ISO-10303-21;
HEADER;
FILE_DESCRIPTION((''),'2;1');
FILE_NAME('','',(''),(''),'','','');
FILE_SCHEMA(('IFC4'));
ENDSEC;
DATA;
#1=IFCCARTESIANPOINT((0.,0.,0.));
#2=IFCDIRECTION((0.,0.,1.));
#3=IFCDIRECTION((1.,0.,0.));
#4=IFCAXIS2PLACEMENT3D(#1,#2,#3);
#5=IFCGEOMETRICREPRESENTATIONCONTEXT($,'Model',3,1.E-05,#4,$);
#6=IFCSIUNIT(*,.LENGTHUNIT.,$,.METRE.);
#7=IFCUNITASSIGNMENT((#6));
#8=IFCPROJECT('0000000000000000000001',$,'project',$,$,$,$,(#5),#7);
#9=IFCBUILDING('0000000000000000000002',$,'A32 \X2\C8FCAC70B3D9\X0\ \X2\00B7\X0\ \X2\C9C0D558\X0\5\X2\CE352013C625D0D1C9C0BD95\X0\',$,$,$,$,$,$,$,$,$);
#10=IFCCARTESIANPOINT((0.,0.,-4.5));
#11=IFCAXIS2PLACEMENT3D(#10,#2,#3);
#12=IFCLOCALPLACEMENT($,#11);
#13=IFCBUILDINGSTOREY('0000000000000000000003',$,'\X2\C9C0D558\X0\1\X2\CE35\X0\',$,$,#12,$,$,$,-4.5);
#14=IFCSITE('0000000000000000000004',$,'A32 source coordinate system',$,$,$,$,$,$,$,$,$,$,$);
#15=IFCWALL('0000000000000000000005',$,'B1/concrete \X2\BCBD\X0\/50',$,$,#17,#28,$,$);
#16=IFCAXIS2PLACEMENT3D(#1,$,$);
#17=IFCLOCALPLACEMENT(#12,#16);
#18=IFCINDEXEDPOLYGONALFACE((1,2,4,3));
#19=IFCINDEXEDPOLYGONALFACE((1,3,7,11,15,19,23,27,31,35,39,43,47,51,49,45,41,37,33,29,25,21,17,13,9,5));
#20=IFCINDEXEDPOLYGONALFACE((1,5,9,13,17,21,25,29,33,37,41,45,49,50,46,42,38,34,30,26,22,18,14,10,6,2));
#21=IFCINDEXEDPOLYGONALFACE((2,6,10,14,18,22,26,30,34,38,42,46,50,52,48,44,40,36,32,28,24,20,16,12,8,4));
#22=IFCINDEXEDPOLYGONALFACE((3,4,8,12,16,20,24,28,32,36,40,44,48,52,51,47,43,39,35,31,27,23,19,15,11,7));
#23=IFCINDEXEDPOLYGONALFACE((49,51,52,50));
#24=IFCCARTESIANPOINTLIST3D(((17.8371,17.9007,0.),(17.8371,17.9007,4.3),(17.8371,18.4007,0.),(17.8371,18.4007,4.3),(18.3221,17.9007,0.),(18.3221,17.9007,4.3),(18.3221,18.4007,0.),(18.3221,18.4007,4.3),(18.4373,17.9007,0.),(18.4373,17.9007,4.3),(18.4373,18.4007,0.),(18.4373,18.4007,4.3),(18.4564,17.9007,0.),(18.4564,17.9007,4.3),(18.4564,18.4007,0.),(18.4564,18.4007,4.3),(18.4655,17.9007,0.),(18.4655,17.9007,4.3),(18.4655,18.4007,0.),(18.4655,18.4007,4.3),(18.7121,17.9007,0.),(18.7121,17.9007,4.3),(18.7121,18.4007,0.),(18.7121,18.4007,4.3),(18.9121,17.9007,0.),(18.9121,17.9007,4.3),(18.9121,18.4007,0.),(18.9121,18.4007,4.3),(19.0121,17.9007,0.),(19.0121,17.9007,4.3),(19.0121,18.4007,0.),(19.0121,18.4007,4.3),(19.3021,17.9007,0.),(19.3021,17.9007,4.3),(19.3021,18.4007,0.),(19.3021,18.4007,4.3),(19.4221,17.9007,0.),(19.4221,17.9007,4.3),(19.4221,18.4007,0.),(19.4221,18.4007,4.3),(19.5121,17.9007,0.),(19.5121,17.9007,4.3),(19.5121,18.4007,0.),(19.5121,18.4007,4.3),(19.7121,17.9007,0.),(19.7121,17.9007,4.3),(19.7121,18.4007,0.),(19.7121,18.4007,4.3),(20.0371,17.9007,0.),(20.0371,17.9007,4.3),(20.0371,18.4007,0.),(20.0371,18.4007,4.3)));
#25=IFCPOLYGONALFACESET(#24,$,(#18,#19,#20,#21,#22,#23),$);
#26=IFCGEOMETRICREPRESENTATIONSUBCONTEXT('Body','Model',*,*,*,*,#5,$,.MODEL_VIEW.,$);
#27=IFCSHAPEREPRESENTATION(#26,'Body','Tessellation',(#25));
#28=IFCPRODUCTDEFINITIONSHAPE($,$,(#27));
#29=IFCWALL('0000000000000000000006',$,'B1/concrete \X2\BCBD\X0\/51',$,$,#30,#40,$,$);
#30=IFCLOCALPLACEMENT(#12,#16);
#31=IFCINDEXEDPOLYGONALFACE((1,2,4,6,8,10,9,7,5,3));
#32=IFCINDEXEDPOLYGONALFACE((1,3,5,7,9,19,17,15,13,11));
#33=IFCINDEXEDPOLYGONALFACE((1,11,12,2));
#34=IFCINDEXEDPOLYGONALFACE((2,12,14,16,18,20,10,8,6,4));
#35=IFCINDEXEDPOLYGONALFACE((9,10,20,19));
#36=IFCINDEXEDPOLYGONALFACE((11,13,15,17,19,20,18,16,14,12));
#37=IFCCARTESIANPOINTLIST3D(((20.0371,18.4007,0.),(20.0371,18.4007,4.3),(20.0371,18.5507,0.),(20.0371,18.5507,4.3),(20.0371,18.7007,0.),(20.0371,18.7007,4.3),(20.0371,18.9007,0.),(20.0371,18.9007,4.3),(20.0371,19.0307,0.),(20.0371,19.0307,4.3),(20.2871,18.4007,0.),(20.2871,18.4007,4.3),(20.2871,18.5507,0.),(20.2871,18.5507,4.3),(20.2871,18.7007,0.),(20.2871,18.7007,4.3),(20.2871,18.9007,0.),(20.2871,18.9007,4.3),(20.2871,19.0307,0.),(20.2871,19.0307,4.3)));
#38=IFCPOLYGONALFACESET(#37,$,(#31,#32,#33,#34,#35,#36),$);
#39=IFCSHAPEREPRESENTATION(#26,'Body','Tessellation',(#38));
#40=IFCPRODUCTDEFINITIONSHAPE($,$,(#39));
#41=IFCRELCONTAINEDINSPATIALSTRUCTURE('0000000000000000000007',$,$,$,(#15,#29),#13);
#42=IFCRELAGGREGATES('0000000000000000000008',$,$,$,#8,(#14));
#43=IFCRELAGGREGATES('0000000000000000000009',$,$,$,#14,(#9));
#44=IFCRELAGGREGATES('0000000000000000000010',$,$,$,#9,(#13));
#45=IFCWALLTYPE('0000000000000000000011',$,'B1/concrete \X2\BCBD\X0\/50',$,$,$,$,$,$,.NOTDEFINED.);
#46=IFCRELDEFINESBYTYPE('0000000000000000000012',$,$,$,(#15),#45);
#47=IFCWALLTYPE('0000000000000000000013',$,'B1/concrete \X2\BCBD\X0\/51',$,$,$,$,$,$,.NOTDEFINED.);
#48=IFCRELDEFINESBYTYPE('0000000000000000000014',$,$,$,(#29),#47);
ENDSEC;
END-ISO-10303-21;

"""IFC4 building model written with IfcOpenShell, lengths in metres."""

from ifc_helpers import new_model, si_unit, frame, origin, origin_with_axes, place, context, subcontext, project, spatial, polyline, outline, extrude, source, transform, mapped, type_object, type_shapes, element, save


model = new_model("IFC4")

# Units and contexts
model_context = context("Model", 3, precision=1e-05, world=origin_with_axes())
body_context = subcontext(model_context, "Body", "Model", "MODEL_VIEW")
ifc_project = project(units=[si_unit("LENGTHUNIT", "METRE")], contexts=[model_context])

# Site, building, storey
site = spatial("IfcSite", under=ifc_project, Name="A32 source coordinate system")
building = spatial("IfcBuilding", under=site, Name="A32 주거동 · 지하5층–옥탑지붕")
storey_placement = place(None, frame((0.0, 0.0, -4.5), z_axis=(0.0, 0.0, 1.0), x_axis=(1.0, 0.0, 0.0)))
storey = spatial("IfcBuildingStorey", under=building, at=storey_placement, Name="지하1층", Elevation=-4.5)

# Walls
wall_type_1 = type_object("IfcWallType", Name="B1/concrete 벽/50", PredefinedType="NOTDEFINED")
shared_shape_1 = source(origin(), body_context, "Body", "SweptSolid", [
    extrude(outline(polyline([(18.4373, 18.4007), (18.4564, 18.4007), (18.4655, 18.4007), (18.7121, 18.4007), (18.9121, 18.4007), (19.0121, 18.4007), (19.3021, 18.4007), (19.4221, 18.4007), (19.5121, 18.4007), (19.7121, 18.4007), (20.0371, 18.4007), (20.0371, 17.9007), (19.7121, 17.9007), (19.5121, 17.9007), (19.4221, 17.9007), (19.3021, 17.9007), (19.0121, 17.9007), (18.9121, 17.9007), (18.7121, 17.9007), (18.4655, 17.9007), (18.4564, 17.9007), (18.4373, 17.9007), (18.3221, 17.9007), (17.8371, 17.9007), (17.8371, 18.4007), (18.3221, 18.4007), (18.4373, 18.4007)])), origin(), (0.0, 0.0, 1.0), 4.3),
])
type_shapes(wall_type_1, [shared_shape_1])
wall_1_placement = place(storey_placement, origin_with_axes())
element("IfcWall", 1, at=wall_1_placement, inside=storey, type_object=wall_type_1, Name="B1/concrete 벽/50", context=body_context, shape_type="MappedRepresentation", body=[
    mapped(shared_shape_1, transform((0.0, 0.0, 0.0), scale=1.0)),
])
wall_type_2 = type_object("IfcWallType", Name="B1/concrete 벽/51", PredefinedType="NOTDEFINED")
shared_shape_2 = source(origin(), body_context, "Body", "SweptSolid", [
    extrude(outline(polyline([(20.0371, 18.9007), (20.0371, 19.0307), (20.2871, 19.0307), (20.2871, 18.9007), (20.2871, 18.7007), (20.2871, 18.5507), (20.2871, 18.4007), (20.0371, 18.4007), (20.0371, 18.5507), (20.0371, 18.7007), (20.0371, 18.9007)])), origin(), (0.0, 0.0, 1.0), 4.3),
])
type_shapes(wall_type_2, [shared_shape_2])
wall_2_placement = place(storey_placement, origin_with_axes())
element("IfcWall", 2, at=wall_2_placement, inside=storey, type_object=wall_type_2, Name="B1/concrete 벽/51", context=body_context, shape_type="MappedRepresentation", body=[
    mapped(shared_shape_2, transform((0.0, 0.0, 0.0), scale=1.0)),
])

save(model, "model.ifc")
